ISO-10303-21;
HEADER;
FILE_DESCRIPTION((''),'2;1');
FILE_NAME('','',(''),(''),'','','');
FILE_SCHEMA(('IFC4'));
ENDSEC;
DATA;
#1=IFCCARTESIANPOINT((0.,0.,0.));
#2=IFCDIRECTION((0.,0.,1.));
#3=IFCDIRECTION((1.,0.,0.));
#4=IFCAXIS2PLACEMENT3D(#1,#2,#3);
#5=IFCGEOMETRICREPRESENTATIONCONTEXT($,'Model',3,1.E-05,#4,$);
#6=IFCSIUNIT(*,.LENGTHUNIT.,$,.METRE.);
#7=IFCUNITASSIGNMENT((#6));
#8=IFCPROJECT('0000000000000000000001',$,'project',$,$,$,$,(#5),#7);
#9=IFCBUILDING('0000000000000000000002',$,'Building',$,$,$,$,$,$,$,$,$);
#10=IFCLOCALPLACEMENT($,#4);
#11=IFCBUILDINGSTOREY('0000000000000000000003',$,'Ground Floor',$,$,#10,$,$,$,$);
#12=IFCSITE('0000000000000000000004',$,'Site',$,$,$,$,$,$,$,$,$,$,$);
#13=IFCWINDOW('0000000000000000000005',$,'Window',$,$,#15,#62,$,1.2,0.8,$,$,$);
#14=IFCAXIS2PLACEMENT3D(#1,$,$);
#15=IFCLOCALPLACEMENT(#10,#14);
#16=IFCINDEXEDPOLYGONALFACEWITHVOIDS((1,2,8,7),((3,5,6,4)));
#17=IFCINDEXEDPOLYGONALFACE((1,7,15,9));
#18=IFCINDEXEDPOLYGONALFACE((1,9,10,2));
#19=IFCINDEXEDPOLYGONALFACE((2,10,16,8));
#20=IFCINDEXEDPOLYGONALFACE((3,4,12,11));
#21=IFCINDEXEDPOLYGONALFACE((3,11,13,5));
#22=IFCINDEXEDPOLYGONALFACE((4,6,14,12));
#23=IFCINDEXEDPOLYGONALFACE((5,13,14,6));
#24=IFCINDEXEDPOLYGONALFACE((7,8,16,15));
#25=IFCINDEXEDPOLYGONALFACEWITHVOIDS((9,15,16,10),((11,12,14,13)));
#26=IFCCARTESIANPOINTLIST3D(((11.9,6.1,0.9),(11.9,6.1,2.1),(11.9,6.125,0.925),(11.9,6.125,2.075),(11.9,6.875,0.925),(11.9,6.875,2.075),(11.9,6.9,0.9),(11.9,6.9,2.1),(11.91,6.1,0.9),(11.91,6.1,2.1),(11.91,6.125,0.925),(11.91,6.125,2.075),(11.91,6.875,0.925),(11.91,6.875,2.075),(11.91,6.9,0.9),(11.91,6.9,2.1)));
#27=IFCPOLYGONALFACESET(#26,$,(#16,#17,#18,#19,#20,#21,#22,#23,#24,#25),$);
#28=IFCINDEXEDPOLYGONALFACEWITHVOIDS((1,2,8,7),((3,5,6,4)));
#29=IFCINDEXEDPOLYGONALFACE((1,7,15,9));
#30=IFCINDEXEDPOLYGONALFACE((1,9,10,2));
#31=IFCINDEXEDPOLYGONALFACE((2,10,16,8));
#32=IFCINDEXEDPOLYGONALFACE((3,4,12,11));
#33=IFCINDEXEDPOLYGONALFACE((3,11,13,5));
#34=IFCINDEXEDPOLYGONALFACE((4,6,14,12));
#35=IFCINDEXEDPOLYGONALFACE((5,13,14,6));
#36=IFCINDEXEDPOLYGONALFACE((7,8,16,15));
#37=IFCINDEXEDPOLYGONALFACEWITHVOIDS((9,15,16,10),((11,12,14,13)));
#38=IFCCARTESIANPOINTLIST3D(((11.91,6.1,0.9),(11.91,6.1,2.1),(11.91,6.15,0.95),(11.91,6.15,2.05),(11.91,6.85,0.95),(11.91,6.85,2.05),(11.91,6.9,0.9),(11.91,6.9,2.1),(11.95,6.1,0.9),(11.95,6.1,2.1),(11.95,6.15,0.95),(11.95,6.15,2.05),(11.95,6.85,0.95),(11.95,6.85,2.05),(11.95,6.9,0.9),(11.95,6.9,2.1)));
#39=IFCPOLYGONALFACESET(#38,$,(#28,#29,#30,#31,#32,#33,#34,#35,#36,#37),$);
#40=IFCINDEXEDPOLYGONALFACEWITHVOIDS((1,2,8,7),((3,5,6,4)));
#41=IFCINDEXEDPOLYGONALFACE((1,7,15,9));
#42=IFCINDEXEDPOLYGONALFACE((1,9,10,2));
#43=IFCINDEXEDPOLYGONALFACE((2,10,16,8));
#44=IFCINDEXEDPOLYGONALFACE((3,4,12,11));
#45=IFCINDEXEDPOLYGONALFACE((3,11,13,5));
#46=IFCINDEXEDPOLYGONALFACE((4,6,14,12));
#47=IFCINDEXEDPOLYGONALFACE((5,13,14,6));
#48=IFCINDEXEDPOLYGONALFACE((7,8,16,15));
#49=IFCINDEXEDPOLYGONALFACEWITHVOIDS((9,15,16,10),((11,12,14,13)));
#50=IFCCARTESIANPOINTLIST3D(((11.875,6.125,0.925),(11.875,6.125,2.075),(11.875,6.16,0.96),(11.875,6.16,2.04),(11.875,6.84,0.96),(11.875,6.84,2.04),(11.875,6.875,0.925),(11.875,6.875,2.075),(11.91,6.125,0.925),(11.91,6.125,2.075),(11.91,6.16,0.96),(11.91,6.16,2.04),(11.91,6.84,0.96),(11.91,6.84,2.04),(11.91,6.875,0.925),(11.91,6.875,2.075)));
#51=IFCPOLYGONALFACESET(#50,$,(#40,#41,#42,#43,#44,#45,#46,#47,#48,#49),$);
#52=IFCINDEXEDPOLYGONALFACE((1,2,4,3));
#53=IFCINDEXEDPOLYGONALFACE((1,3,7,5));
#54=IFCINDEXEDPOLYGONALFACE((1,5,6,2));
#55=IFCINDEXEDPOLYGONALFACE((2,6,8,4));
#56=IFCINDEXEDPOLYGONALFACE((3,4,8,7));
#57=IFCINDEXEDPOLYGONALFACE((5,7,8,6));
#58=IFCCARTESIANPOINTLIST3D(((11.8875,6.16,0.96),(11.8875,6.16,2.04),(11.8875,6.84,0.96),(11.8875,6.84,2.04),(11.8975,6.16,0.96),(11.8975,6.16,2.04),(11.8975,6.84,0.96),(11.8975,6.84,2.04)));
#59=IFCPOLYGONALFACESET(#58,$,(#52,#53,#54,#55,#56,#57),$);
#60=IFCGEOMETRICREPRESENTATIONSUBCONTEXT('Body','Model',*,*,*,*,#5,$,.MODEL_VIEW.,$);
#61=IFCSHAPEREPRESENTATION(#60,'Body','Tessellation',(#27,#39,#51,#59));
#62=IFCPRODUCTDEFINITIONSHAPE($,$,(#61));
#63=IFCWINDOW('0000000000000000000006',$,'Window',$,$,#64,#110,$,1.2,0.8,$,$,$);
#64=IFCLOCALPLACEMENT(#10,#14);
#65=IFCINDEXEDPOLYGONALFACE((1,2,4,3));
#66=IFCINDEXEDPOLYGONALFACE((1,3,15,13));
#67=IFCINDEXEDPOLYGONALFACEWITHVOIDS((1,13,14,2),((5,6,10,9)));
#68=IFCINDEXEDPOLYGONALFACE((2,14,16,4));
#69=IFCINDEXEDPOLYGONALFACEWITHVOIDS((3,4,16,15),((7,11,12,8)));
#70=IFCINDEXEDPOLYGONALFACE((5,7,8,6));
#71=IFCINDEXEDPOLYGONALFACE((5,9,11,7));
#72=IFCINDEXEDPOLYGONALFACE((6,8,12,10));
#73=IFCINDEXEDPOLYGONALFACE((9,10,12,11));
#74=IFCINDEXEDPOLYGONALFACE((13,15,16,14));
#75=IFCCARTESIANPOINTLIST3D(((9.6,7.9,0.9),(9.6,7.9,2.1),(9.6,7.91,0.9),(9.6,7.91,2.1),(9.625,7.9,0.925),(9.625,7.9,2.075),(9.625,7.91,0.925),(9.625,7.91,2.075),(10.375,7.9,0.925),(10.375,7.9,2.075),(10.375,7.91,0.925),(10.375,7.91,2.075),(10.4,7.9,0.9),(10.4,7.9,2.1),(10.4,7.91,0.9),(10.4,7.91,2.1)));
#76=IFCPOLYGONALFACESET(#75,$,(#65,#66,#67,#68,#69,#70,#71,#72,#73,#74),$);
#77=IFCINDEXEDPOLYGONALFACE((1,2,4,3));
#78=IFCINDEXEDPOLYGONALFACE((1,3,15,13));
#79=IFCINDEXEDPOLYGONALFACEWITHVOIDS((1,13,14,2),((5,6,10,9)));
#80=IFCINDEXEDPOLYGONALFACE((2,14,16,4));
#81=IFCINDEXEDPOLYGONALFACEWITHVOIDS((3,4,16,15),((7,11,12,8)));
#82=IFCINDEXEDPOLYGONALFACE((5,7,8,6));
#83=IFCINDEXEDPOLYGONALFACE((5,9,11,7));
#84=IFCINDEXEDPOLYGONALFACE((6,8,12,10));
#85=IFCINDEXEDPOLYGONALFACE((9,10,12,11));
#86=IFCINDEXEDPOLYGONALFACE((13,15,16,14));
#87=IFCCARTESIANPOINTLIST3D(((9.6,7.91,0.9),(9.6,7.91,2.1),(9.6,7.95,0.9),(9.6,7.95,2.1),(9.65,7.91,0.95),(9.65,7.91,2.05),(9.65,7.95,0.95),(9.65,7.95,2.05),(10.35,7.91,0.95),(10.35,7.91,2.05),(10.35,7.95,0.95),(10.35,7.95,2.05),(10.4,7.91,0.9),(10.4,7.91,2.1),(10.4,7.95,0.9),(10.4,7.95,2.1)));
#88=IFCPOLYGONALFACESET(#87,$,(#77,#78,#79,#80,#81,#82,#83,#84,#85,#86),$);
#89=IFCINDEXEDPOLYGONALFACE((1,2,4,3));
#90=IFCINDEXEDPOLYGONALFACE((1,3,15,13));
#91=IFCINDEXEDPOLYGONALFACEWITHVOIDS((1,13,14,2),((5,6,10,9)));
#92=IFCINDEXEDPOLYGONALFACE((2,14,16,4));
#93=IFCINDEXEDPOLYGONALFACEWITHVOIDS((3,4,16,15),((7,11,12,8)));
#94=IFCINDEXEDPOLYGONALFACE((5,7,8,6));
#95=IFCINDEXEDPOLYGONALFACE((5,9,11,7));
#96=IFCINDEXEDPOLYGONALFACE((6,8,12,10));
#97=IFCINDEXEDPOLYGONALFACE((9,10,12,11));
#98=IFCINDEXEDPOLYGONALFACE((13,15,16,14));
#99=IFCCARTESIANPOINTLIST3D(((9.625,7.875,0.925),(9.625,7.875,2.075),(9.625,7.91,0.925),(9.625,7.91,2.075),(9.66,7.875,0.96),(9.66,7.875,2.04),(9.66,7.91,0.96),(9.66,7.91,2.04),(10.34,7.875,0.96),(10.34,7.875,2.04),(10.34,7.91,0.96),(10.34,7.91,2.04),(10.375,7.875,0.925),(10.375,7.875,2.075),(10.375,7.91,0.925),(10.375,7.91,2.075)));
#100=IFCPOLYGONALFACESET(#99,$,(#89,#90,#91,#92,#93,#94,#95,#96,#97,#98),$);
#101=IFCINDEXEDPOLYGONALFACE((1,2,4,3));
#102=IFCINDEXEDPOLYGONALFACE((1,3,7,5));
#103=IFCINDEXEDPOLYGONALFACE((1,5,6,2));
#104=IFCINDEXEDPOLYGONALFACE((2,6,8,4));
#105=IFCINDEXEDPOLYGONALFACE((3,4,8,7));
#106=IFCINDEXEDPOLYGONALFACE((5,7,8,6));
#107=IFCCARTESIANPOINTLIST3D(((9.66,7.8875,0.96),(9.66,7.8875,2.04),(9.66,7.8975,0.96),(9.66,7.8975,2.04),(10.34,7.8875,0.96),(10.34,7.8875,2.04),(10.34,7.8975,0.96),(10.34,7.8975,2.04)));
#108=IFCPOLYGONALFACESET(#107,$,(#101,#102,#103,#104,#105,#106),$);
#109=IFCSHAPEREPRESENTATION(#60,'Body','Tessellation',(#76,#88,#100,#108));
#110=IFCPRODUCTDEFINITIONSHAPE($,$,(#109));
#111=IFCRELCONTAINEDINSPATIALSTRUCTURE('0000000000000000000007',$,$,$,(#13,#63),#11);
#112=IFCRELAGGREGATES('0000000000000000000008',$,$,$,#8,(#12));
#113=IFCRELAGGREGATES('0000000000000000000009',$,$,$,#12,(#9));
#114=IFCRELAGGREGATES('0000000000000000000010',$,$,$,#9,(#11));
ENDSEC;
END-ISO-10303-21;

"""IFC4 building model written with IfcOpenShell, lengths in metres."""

from ifc_helpers import new_model, si_unit, frame, origin_with_axes, place, context, subcontext, project, spatial, line, indexed_curve, outline, extrude, element, save


model = new_model("IFC4")

# Units and contexts
model_context = context("Model", 3, precision=1e-05, world=origin_with_axes())
body_context = subcontext(model_context, "Body", "Model", "MODEL_VIEW")
ifc_project = project(units=[si_unit("LENGTHUNIT", "METRE")], contexts=[model_context])

# Site, building, storey
site = spatial("IfcSite", under=ifc_project, Name="Site")
building = spatial("IfcBuilding", under=site, Name="Building")
storey_placement = place(None, origin_with_axes())
storey = spatial("IfcBuildingStorey", under=building, at=storey_placement, Name="Ground Floor")

# Windows
for number, where, z_axis, x_axis, name in (
    (1, (12.0, 6.1, 0.9), (0.0, 0.0, 1.0), (0.0, 1.0, 0.0), "Window"),
    (2, (10.4, 8.0, 0.9), (0.0, 0.0, 1.0), (-1.0, 0.0, 0.0), "Window"),
):
    element("IfcWindow", number, at=place(storey_placement, frame(where, z_axis=z_axis, x_axis=x_axis)), inside=storey, Name=name, OverallHeight=1.2, OverallWidth=0.8, context=body_context, shape_type="SweptSolid", body=[
        extrude(outline(indexed_curve([(0.0, 0.0), (0.8, 0.0), (0.8, 1.2), (0.0, 1.2)], segments=[line(1, 2, 3, 4, 1)]), holes=[indexed_curve([(0.025, 0.025), (0.775, 0.025), (0.775, 1.175), (0.025, 1.175)], segments=[line(1, 2, 3, 4, 1)])]), frame((0.0, 0.09, 0.0), z_axis=(0.0, -1.0, 0.0), x_axis=(1.0, 0.0, 0.0)), (0.0, 0.0, -1.0), 0.01),
        extrude(outline(indexed_curve([(0.0, 0.0), (0.8, 0.0), (0.8, 1.2), (0.0, 1.2)], segments=[line(1, 2, 3, 4, 1)]), holes=[indexed_curve([(0.05, 0.05), (0.75, 0.05), (0.75, 1.15), (0.05, 1.15)], segments=[line(1, 2, 3, 4, 1)])]), frame((0.0, 0.05, 0.0), z_axis=(0.0, -1.0, 0.0), x_axis=(1.0, 0.0, 0.0)), (0.0, 0.0, -1.0), 0.04),
        extrude(outline(indexed_curve([(0.0, 0.0), (0.75, 0.0), (0.75, 1.15), (0.0, 1.15)], segments=[line(1, 2, 3, 4, 1)]), holes=[indexed_curve([(0.035, 0.035), (0.715, 0.035), (0.715, 1.115), (0.035, 1.115)], segments=[line(1, 2, 3, 4, 1)])]), frame((0.025, 0.09, 0.025), z_axis=(0.0, -1.0, 0.0), x_axis=(1.0, 0.0, 0.0)), (0.0, 0.0, -1.0), 0.035),
        extrude(outline(indexed_curve([(0.035, 0.035), (0.715, 0.035), (0.715, 1.115), (0.035, 1.115)], segments=[line(1, 2, 3, 4, 1)])), frame((0.025, 0.1025, 0.025), z_axis=(0.0, -1.0, 0.0), x_axis=(1.0, 0.0, 0.0)), (0.0, 0.0, -1.0), 0.01),
    ])

save(model, "model.ifc")
